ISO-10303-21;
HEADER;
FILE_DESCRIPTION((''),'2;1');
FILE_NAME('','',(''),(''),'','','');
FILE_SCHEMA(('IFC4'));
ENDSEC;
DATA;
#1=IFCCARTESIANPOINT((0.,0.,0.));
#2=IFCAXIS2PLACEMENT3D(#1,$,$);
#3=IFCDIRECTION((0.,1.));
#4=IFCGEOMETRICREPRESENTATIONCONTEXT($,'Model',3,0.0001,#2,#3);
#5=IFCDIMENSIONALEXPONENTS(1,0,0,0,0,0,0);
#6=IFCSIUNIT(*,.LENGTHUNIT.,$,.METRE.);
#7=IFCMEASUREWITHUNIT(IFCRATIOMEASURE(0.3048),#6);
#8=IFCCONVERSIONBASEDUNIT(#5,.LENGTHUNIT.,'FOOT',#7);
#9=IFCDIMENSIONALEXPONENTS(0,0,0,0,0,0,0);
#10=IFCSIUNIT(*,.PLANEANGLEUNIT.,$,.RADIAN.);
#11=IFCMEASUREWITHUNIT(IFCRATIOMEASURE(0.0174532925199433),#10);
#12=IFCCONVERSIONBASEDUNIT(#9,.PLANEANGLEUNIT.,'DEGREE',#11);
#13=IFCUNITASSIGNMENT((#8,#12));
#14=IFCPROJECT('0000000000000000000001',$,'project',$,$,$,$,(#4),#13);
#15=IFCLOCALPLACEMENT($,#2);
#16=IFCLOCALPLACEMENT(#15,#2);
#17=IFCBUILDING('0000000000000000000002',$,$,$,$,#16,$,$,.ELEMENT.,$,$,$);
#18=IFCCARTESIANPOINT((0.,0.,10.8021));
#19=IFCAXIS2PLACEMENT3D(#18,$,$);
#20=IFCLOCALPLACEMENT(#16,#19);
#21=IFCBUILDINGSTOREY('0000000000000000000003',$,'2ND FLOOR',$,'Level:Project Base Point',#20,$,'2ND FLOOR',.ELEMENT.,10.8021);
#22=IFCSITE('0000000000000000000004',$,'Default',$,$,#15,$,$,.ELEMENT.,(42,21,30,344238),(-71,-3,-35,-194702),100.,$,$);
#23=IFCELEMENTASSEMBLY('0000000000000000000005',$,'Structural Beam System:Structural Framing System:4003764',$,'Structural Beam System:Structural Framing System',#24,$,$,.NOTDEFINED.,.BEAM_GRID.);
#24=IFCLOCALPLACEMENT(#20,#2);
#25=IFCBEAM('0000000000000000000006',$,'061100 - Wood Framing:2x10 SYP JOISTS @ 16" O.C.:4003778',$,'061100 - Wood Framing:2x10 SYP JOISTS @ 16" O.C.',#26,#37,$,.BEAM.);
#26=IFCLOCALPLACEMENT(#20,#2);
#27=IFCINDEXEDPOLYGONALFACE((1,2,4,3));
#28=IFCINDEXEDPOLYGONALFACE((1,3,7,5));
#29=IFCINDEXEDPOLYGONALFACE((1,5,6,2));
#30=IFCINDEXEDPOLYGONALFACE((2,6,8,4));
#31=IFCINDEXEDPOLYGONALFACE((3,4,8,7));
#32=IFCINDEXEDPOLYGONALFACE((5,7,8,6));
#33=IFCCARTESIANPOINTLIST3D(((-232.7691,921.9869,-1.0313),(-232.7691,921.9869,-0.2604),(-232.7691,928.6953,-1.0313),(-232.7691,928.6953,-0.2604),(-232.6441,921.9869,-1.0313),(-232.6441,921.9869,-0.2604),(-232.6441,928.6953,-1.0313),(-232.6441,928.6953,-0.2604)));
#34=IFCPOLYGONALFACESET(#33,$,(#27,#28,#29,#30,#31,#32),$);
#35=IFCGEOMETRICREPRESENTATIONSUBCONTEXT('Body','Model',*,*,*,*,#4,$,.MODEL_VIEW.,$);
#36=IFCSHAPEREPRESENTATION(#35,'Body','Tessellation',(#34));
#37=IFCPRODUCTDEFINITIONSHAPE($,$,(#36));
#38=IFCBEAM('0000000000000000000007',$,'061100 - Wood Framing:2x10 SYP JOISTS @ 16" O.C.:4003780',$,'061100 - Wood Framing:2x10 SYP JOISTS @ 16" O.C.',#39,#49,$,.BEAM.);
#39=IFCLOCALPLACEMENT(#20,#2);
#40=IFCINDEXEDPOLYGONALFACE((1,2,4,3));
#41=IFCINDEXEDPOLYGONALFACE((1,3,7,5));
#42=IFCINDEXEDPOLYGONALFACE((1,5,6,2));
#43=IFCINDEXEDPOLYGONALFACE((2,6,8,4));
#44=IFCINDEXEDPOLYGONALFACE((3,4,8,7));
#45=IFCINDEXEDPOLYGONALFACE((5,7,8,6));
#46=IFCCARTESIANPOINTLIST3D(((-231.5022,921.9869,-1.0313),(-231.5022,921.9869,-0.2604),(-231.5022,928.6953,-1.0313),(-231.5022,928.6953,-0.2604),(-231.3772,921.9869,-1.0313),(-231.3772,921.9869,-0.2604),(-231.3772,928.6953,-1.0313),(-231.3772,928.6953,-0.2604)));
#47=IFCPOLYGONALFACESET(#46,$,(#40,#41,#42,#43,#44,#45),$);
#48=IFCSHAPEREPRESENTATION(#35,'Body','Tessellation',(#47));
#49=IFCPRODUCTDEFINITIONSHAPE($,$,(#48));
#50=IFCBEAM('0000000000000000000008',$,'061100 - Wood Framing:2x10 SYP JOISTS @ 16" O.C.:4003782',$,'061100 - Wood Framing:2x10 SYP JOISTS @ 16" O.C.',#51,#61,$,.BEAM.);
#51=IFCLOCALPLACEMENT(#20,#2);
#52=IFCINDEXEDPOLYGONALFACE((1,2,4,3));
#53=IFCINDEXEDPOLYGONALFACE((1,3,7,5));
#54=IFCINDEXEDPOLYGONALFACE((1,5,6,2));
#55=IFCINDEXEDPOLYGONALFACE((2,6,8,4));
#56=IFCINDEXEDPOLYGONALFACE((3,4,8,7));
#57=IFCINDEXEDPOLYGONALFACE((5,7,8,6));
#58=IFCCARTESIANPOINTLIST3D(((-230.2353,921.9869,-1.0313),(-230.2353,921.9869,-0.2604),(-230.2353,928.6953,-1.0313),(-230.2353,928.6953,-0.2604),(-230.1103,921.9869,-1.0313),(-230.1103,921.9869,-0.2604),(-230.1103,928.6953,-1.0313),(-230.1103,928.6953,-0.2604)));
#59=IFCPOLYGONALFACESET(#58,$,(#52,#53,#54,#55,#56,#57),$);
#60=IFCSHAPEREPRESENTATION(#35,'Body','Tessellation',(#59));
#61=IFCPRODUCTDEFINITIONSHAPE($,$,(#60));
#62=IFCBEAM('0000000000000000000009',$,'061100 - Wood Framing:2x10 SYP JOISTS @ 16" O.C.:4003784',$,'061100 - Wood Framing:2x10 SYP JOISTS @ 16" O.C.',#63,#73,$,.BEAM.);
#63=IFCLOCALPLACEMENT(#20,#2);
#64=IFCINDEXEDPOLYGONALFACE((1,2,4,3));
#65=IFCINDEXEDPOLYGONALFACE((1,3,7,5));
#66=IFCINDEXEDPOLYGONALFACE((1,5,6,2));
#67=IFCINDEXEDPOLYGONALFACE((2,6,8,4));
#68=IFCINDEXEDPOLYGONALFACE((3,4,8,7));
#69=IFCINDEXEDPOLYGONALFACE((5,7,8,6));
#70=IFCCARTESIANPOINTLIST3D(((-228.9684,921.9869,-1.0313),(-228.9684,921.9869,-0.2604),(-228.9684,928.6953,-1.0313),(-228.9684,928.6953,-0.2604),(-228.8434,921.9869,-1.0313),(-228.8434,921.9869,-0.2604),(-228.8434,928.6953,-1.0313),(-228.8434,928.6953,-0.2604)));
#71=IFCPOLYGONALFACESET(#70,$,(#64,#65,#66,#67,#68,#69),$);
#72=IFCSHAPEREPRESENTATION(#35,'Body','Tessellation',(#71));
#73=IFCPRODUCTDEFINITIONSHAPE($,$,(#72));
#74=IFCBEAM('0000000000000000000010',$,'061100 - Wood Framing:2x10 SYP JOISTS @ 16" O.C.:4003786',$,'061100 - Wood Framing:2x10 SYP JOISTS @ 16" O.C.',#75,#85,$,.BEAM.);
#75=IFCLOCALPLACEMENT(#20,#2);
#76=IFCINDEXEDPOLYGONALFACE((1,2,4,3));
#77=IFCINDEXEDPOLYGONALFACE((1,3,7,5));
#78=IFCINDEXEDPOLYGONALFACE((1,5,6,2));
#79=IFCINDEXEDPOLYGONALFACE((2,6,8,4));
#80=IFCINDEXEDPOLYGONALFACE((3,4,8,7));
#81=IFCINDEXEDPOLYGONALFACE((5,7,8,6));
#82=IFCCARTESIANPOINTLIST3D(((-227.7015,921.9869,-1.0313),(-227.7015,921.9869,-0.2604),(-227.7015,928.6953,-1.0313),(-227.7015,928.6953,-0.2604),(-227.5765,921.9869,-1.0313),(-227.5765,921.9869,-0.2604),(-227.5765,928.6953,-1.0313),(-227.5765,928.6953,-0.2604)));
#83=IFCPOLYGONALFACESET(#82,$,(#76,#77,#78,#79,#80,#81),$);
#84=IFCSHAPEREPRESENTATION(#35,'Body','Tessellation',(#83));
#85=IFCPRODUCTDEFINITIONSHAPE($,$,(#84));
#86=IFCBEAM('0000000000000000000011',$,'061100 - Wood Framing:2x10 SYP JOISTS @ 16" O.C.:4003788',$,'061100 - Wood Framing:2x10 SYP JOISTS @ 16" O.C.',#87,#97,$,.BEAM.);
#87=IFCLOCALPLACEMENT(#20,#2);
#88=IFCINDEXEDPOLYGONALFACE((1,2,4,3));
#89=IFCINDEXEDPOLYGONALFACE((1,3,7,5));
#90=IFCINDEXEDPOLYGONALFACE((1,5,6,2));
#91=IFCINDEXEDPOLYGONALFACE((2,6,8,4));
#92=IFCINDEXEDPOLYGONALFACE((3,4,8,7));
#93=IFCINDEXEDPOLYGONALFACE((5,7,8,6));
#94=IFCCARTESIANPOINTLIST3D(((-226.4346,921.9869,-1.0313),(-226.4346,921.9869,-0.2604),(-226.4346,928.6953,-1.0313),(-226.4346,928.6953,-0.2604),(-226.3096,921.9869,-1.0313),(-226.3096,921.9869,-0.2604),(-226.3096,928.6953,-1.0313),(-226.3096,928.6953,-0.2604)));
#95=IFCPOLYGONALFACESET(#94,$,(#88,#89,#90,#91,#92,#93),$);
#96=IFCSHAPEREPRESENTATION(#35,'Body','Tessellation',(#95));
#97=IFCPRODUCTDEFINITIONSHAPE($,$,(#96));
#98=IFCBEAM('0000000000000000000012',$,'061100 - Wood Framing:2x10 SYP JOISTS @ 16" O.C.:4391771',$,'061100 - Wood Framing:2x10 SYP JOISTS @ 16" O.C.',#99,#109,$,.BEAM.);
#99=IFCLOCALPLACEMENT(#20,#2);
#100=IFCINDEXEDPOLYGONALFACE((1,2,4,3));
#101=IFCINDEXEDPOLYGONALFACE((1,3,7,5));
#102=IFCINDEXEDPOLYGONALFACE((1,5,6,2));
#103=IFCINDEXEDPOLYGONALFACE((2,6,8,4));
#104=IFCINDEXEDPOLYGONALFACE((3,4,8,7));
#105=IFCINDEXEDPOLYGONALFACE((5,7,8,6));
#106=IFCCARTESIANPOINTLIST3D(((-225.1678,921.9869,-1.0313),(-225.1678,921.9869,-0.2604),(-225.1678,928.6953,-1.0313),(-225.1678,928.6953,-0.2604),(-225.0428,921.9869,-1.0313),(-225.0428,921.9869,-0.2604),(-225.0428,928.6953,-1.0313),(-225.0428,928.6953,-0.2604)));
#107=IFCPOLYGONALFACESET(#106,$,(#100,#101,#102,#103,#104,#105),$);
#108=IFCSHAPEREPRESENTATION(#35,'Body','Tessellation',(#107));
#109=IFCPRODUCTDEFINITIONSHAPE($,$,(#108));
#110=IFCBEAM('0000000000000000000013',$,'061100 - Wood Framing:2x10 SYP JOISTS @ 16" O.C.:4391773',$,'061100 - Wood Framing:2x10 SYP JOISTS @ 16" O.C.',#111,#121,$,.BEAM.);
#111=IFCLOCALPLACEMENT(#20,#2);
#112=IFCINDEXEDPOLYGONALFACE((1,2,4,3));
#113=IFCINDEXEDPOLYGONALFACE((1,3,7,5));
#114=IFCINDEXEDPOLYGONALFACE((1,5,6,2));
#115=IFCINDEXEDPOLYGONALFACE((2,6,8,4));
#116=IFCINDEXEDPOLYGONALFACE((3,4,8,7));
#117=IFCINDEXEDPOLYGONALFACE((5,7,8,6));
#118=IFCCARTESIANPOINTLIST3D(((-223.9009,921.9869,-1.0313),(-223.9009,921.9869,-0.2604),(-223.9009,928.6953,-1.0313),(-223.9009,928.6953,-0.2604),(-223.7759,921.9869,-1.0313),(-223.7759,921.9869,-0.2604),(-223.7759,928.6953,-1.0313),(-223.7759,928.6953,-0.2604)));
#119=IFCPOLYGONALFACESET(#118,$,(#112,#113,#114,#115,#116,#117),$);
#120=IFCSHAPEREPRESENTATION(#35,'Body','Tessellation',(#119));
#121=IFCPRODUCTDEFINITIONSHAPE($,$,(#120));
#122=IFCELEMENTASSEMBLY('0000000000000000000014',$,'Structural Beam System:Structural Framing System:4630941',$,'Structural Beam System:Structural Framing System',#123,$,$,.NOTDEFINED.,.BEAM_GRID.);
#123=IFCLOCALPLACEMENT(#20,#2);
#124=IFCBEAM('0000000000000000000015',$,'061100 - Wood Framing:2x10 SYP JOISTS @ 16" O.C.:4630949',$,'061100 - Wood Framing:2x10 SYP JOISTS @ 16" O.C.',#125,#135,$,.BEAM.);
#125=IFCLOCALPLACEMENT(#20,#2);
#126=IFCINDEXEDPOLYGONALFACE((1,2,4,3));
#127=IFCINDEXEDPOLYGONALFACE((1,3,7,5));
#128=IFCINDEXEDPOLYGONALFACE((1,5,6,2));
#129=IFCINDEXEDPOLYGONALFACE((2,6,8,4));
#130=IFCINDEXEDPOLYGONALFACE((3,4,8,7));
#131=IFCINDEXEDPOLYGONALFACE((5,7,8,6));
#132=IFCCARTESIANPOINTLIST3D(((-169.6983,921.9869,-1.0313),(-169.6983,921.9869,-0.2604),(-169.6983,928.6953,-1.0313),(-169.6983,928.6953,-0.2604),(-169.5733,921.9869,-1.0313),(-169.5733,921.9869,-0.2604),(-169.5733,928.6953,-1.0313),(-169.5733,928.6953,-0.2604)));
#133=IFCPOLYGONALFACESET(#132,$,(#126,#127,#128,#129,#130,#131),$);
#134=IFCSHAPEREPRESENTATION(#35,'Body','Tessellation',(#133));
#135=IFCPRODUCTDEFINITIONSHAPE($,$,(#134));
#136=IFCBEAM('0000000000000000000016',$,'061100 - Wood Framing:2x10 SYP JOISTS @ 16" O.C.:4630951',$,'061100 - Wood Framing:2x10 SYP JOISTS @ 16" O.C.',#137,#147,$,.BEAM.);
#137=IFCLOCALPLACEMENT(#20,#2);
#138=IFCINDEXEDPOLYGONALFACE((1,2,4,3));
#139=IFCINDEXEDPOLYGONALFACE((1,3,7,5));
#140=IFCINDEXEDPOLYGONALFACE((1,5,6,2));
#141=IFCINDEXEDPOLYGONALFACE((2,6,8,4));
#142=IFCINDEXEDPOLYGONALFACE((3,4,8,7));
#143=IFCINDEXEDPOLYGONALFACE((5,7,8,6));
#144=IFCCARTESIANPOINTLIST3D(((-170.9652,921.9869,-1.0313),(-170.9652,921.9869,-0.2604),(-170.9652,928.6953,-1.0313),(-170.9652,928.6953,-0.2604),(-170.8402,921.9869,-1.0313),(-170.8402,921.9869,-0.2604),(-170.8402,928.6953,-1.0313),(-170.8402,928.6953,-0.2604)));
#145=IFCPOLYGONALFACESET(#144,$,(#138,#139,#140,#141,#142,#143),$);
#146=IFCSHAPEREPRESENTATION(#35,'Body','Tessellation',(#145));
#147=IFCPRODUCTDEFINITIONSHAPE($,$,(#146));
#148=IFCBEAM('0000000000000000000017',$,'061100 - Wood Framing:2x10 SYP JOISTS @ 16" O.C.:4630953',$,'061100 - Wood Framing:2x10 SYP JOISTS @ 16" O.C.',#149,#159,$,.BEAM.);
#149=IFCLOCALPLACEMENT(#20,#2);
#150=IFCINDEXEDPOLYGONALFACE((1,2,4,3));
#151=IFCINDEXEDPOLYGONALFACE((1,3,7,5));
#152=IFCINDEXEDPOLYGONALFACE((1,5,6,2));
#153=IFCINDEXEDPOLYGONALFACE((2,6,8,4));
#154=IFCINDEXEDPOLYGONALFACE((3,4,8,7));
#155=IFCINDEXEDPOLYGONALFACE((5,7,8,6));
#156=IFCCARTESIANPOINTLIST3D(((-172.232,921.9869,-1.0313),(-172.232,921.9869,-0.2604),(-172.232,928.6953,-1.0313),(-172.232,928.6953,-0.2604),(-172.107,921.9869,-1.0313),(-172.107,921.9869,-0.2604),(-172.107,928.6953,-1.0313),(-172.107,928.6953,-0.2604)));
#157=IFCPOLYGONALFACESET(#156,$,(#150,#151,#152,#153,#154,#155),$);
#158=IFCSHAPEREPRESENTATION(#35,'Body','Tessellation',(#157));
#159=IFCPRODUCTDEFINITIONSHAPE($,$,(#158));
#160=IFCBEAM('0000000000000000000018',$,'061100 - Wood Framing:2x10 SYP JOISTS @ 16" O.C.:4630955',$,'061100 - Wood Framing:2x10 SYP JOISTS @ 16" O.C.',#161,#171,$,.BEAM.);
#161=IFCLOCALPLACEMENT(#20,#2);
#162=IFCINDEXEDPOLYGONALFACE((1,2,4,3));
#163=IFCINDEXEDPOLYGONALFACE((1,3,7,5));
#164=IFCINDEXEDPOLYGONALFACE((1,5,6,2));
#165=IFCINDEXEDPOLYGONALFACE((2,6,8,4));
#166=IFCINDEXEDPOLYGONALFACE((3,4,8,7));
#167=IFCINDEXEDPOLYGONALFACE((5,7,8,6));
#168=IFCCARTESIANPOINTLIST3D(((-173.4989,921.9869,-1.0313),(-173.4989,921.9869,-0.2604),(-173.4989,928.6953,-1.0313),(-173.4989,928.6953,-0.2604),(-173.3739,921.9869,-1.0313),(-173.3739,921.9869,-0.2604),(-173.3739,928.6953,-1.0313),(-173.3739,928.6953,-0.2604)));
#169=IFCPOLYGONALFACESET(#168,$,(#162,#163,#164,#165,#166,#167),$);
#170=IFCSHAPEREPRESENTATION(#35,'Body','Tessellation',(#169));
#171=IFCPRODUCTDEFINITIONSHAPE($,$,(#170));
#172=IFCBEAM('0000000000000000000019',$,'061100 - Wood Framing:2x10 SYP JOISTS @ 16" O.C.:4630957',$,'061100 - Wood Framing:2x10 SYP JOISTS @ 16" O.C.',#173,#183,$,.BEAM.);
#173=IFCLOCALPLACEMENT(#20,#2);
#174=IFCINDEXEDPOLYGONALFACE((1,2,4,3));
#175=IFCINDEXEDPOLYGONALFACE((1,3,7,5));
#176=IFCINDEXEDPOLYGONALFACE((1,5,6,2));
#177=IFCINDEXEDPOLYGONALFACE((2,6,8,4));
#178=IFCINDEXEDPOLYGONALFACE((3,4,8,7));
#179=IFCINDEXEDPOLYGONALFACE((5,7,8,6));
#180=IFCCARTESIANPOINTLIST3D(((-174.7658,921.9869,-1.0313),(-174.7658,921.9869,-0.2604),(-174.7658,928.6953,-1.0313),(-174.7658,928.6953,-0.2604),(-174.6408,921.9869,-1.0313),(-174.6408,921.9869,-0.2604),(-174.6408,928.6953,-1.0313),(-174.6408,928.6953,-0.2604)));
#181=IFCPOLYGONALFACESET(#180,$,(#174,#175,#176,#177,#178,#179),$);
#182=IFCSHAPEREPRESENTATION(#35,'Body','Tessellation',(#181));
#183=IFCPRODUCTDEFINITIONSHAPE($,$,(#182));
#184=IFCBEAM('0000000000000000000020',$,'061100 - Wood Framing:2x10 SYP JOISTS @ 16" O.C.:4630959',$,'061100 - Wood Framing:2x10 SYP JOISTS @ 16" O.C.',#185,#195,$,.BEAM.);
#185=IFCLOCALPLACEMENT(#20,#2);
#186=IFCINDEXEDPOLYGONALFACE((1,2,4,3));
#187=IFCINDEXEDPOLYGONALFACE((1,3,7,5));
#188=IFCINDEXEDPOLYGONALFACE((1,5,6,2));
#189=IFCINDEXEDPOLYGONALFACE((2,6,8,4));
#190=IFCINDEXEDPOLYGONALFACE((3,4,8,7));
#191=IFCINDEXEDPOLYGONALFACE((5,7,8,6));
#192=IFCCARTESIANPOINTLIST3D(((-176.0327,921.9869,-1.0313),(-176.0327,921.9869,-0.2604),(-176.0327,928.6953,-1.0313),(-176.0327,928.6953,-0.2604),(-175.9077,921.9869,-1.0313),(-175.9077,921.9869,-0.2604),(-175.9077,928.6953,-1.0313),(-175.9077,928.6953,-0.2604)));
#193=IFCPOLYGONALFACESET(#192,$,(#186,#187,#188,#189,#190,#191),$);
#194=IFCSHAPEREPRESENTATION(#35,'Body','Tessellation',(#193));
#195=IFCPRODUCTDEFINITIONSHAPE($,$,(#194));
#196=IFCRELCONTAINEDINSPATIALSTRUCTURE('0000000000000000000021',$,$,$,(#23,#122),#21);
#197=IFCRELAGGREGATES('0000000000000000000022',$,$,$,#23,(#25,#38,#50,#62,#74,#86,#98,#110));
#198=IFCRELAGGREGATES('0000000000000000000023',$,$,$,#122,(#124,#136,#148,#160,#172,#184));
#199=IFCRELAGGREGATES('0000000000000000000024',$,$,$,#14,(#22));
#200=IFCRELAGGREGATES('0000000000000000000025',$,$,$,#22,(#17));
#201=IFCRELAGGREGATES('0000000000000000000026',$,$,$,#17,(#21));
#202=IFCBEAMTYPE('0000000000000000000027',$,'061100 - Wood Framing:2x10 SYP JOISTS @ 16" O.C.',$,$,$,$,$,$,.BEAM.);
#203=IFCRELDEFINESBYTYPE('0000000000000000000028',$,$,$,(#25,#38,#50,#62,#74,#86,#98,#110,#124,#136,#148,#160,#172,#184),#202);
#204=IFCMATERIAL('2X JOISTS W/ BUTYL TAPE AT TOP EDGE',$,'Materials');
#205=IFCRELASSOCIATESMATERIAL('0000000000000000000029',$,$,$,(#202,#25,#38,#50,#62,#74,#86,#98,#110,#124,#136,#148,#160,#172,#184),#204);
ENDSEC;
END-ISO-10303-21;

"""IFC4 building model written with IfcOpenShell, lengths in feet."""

from ifc_helpers import new_model, entity, si_unit, converted_unit, direction, frame, frame_2d, origin, place, context, subcontext, project, spatial, rectangle, extrude, source, transform, mapped, material, material_profile, profile_set, profile_usage, type_object, type_shapes, element, aggregate, save


model = new_model("IFC4")

# Units and contexts
model_context = context("Model", 3, precision=0.0001, world=origin(), true_north=direction((0.0, 1.0)))
body_context = subcontext(model_context, "Body", "Model", "MODEL_VIEW")
ifc_project = project(units=[converted_unit("LENGTHUNIT", "FOOT", entity("IfcRatioMeasure", 0.3048), si_unit("LENGTHUNIT", "METRE"), dimensions=[1, 0, 0, 0, 0, 0, 0]), converted_unit("PLANEANGLEUNIT", "DEGREE", entity("IfcRatioMeasure", 0.0174532925199433), si_unit("PLANEANGLEUNIT", "RADIAN"), dimensions=[0, 0, 0, 0, 0, 0, 0])], contexts=[model_context])

# Site, building, storey
site_placement = place(None, origin())
site = spatial("IfcSite", under=ifc_project, at=site_placement, Name="Default", CompositionType="ELEMENT", RefLatitude=(42, 21, 30, 344238), RefLongitude=(-71, -3, -35, -194702), RefElevation=100.0)
building_placement = place(site_placement, origin())
building = spatial("IfcBuilding", under=site, at=building_placement, CompositionType="ELEMENT")
storey_placement = place(building_placement, frame((0.0, 0.0, 10.8021)))
storey = spatial("IfcBuildingStorey", under=building, at=storey_placement, Name="2ND FLOOR", ObjectType="Level:Project Base Point", LongName="2ND FLOOR", CompositionType="ELEMENT", Elevation=10.8021)

# Element assemblies, beams
assembly_1_placement = place(storey_placement, origin())
assembly_1 = element("IfcElementAssembly", 1, at=assembly_1_placement, inside=storey, Name="Structural Beam System:Structural Framing System:4003764", ObjectType="Structural Beam System:Structural Framing System", AssemblyPlace="NOTDEFINED", PredefinedType="BEAM_GRID")
ifc_material_1 = material(Name="2X JOISTS W/ BUTYL TAPE AT TOP EDGE", Category="Materials")
ifc_material_profile_1 = material_profile(ifc_material_1, rectangle(XDim=0.7708, YDim=0.125, at=frame_2d((0.0, 0.0), x_axis=(1.0, 0.0))), Name="2x10 SYP JOISTS @ 16\" O.C.")
ifc_profile_set_1 = profile_set([ifc_material_profile_1], Name="2x10 SYP JOISTS @ 16\" O.C.")
ifc_profile_usage_1 = profile_usage(ifc_profile_set_1, cardinal=8)
beam_type_1 = type_object("IfcBeamType", Name="061100 - Wood Framing:2x10 SYP JOISTS @ 16\" O.C.", PredefinedType="BEAM", material=ifc_profile_set_1)
shared_shape_1 = source(origin(), body_context, "Body", "SweptSolid", [
    extrude(rectangle(XDim=0.7708, YDim=0.125, at=frame_2d((0.0, 0.0), x_axis=(1.0, 0.0))), frame((-3.3542, 0.0, 0.0), z_axis=(1.0, 0.0, 0.0), x_axis=(0.0, 0.0, -1.0)), (0.0, 0.0, 1.0), 6.7083),
])
type_shapes(beam_type_1, [shared_shape_1])
beam_1_placement = place(assembly_1_placement, frame((-232.7066, 925.3411, -0.6458), z_axis=(0.0, 0.0, 1.0), x_axis=(0.0, 1.0, 0.0)))
beam_1 = element("IfcBeam", 2, at=beam_1_placement, type_object=beam_type_1, material=ifc_profile_usage_1, Name="061100 - Wood Framing:2x10 SYP JOISTS @ 16\" O.C.:4003778", ObjectType="061100 - Wood Framing:2x10 SYP JOISTS @ 16\" O.C.", PredefinedType="BEAM", context=body_context, shape_type="MappedRepresentation", body=[
    mapped(shared_shape_1, transform((0.0, 0.0, 0.0), scale=1.0)),
])
ifc_profile_usage_2 = profile_usage(ifc_profile_set_1, cardinal=8)
beam_2_placement = place(assembly_1_placement, frame((-231.4397, 925.3411, -0.6458), z_axis=(0.0, 0.0, 1.0), x_axis=(0.0, 1.0, 0.0)))
beam_2 = element("IfcBeam", 3, at=beam_2_placement, type_object=beam_type_1, material=ifc_profile_usage_2, Name="061100 - Wood Framing:2x10 SYP JOISTS @ 16\" O.C.:4003780", ObjectType="061100 - Wood Framing:2x10 SYP JOISTS @ 16\" O.C.", PredefinedType="BEAM", context=body_context, shape_type="MappedRepresentation", body=[
    mapped(shared_shape_1, transform((0.0, 0.0, 0.0), scale=1.0)),
])
ifc_profile_usage_3 = profile_usage(ifc_profile_set_1, cardinal=8)
beam_3_placement = place(assembly_1_placement, frame((-230.1728, 925.3411, -0.6458), z_axis=(0.0, 0.0, 1.0), x_axis=(0.0, 1.0, 0.0)))
beam_3 = element("IfcBeam", 4, at=beam_3_placement, type_object=beam_type_1, material=ifc_profile_usage_3, Name="061100 - Wood Framing:2x10 SYP JOISTS @ 16\" O.C.:4003782", ObjectType="061100 - Wood Framing:2x10 SYP JOISTS @ 16\" O.C.", PredefinedType="BEAM", context=body_context, shape_type="MappedRepresentation", body=[
    mapped(shared_shape_1, transform((0.0, 0.0, 0.0), scale=1.0)),
])
ifc_profile_usage_4 = profile_usage(ifc_profile_set_1, cardinal=8)
beam_4_placement = place(assembly_1_placement, frame((-228.9059, 925.3411, -0.6458), z_axis=(0.0, 0.0, 1.0), x_axis=(0.0, 1.0, 0.0)))
beam_4 = element("IfcBeam", 5, at=beam_4_placement, type_object=beam_type_1, material=ifc_profile_usage_4, Name="061100 - Wood Framing:2x10 SYP JOISTS @ 16\" O.C.:4003784", ObjectType="061100 - Wood Framing:2x10 SYP JOISTS @ 16\" O.C.", PredefinedType="BEAM", context=body_context, shape_type="MappedRepresentation", body=[
    mapped(shared_shape_1, transform((0.0, 0.0, 0.0), scale=1.0)),
])
ifc_profile_usage_5 = profile_usage(ifc_profile_set_1, cardinal=8)
beam_5_placement = place(assembly_1_placement, frame((-227.639, 925.3411, -0.6458), z_axis=(0.0, 0.0, 1.0), x_axis=(0.0, 1.0, 0.0)))
beam_5 = element("IfcBeam", 6, at=beam_5_placement, type_object=beam_type_1, material=ifc_profile_usage_5, Name="061100 - Wood Framing:2x10 SYP JOISTS @ 16\" O.C.:4003786", ObjectType="061100 - Wood Framing:2x10 SYP JOISTS @ 16\" O.C.", PredefinedType="BEAM", context=body_context, shape_type="MappedRepresentation", body=[
    mapped(shared_shape_1, transform((0.0, 0.0, 0.0), scale=1.0)),
])
ifc_profile_usage_6 = profile_usage(ifc_profile_set_1, cardinal=8)
beam_6_placement = place(assembly_1_placement, frame((-226.3721, 925.3411, -0.6458), z_axis=(0.0, 0.0, 1.0), x_axis=(0.0, 1.0, 0.0)))
beam_6 = element("IfcBeam", 7, at=beam_6_placement, type_object=beam_type_1, material=ifc_profile_usage_6, Name="061100 - Wood Framing:2x10 SYP JOISTS @ 16\" O.C.:4003788", ObjectType="061100 - Wood Framing:2x10 SYP JOISTS @ 16\" O.C.", PredefinedType="BEAM", context=body_context, shape_type="MappedRepresentation", body=[
    mapped(shared_shape_1, transform((0.0, 0.0, 0.0), scale=1.0)),
])
ifc_profile_usage_7 = profile_usage(ifc_profile_set_1, cardinal=8)
beam_7_placement = place(assembly_1_placement, frame((-225.1053, 925.3411, -0.6458), z_axis=(0.0, 0.0, 1.0), x_axis=(0.0, 1.0, 0.0)))
beam_7 = element("IfcBeam", 8, at=beam_7_placement, type_object=beam_type_1, material=ifc_profile_usage_7, Name="061100 - Wood Framing:2x10 SYP JOISTS @ 16\" O.C.:4391771", ObjectType="061100 - Wood Framing:2x10 SYP JOISTS @ 16\" O.C.", PredefinedType="BEAM", context=body_context, shape_type="MappedRepresentation", body=[
    mapped(shared_shape_1, transform((0.0, 0.0, 0.0), scale=1.0)),
])
ifc_profile_usage_8 = profile_usage(ifc_profile_set_1, cardinal=8)
beam_8_placement = place(assembly_1_placement, frame((-223.8384, 925.3411, -0.6458), z_axis=(0.0, 0.0, 1.0), x_axis=(0.0, 1.0, 0.0)))
beam_8 = element("IfcBeam", 9, at=beam_8_placement, type_object=beam_type_1, material=ifc_profile_usage_8, Name="061100 - Wood Framing:2x10 SYP JOISTS @ 16\" O.C.:4391773", ObjectType="061100 - Wood Framing:2x10 SYP JOISTS @ 16\" O.C.", PredefinedType="BEAM", context=body_context, shape_type="MappedRepresentation", body=[
    mapped(shared_shape_1, transform((0.0, 0.0, 0.0), scale=1.0)),
])
aggregate(assembly_1, [beam_1, beam_2, beam_3, beam_4, beam_5, beam_6, beam_7, beam_8])
assembly_2_placement = place(storey_placement, origin())
assembly_2 = element("IfcElementAssembly", 10, at=assembly_2_placement, inside=storey, Name="Structural Beam System:Structural Framing System:4630941", ObjectType="Structural Beam System:Structural Framing System", AssemblyPlace="NOTDEFINED", PredefinedType="BEAM_GRID")
ifc_profile_usage_9 = profile_usage(ifc_profile_set_1, cardinal=8)
beam_9_placement = place(assembly_2_placement, frame((-169.6358, 925.3411, -0.6458), z_axis=(0.0, 0.0, 1.0), x_axis=(0.0, 1.0, 0.0)))
beam_9 = element("IfcBeam", 11, at=beam_9_placement, type_object=beam_type_1, material=ifc_profile_usage_9, Name="061100 - Wood Framing:2x10 SYP JOISTS @ 16\" O.C.:4630949", ObjectType="061100 - Wood Framing:2x10 SYP JOISTS @ 16\" O.C.", PredefinedType="BEAM", context=body_context, shape_type="MappedRepresentation", body=[
    mapped(shared_shape_1, transform((0.0, 0.0, 0.0), scale=1.0)),
])
ifc_profile_usage_10 = profile_usage(ifc_profile_set_1, cardinal=8)
beam_10_placement = place(assembly_2_placement, frame((-170.9027, 925.3411, -0.6458), z_axis=(0.0, 0.0, 1.0), x_axis=(0.0, 1.0, 0.0)))
beam_10 = element("IfcBeam", 12, at=beam_10_placement, type_object=beam_type_1, material=ifc_profile_usage_10, Name="061100 - Wood Framing:2x10 SYP JOISTS @ 16\" O.C.:4630951", ObjectType="061100 - Wood Framing:2x10 SYP JOISTS @ 16\" O.C.", PredefinedType="BEAM", context=body_context, shape_type="MappedRepresentation", body=[
    mapped(shared_shape_1, transform((0.0, 0.0, 0.0), scale=1.0)),
])
ifc_profile_usage_11 = profile_usage(ifc_profile_set_1, cardinal=8)
beam_11_placement = place(assembly_2_placement, frame((-172.1695, 925.3411, -0.6458), z_axis=(0.0, 0.0, 1.0), x_axis=(0.0, 1.0, 0.0)))
beam_11 = element("IfcBeam", 13, at=beam_11_placement, type_object=beam_type_1, material=ifc_profile_usage_11, Name="061100 - Wood Framing:2x10 SYP JOISTS @ 16\" O.C.:4630953", ObjectType="061100 - Wood Framing:2x10 SYP JOISTS @ 16\" O.C.", PredefinedType="BEAM", context=body_context, shape_type="MappedRepresentation", body=[
    mapped(shared_shape_1, transform((0.0, 0.0, 0.0), scale=1.0)),
])
ifc_profile_usage_12 = profile_usage(ifc_profile_set_1, cardinal=8)
beam_12_placement = place(assembly_2_placement, frame((-173.4364, 925.3411, -0.6458), z_axis=(0.0, 0.0, 1.0), x_axis=(0.0, 1.0, 0.0)))
beam_12 = element("IfcBeam", 14, at=beam_12_placement, type_object=beam_type_1, material=ifc_profile_usage_12, Name="061100 - Wood Framing:2x10 SYP JOISTS @ 16\" O.C.:4630955", ObjectType="061100 - Wood Framing:2x10 SYP JOISTS @ 16\" O.C.", PredefinedType="BEAM", context=body_context, shape_type="MappedRepresentation", body=[
    mapped(shared_shape_1, transform((0.0, 0.0, 0.0), scale=1.0)),
])
ifc_profile_usage_13 = profile_usage(ifc_profile_set_1, cardinal=8)
beam_13_placement = place(assembly_2_placement, frame((-174.7033, 925.3411, -0.6458), z_axis=(0.0, 0.0, 1.0), x_axis=(0.0, 1.0, 0.0)))
beam_13 = element("IfcBeam", 15, at=beam_13_placement, type_object=beam_type_1, material=ifc_profile_usage_13, Name="061100 - Wood Framing:2x10 SYP JOISTS @ 16\" O.C.:4630957", ObjectType="061100 - Wood Framing:2x10 SYP JOISTS @ 16\" O.C.", PredefinedType="BEAM", context=body_context, shape_type="MappedRepresentation", body=[
    mapped(shared_shape_1, transform((0.0, 0.0, 0.0), scale=1.0)),
])
ifc_profile_usage_14 = profile_usage(ifc_profile_set_1, cardinal=8)
beam_14_placement = place(assembly_2_placement, frame((-175.9702, 925.3411, -0.6458), z_axis=(0.0, 0.0, 1.0), x_axis=(0.0, 1.0, 0.0)))
beam_14 = element("IfcBeam", 16, at=beam_14_placement, type_object=beam_type_1, material=ifc_profile_usage_14, Name="061100 - Wood Framing:2x10 SYP JOISTS @ 16\" O.C.:4630959", ObjectType="061100 - Wood Framing:2x10 SYP JOISTS @ 16\" O.C.", PredefinedType="BEAM", context=body_context, shape_type="MappedRepresentation", body=[
    mapped(shared_shape_1, transform((0.0, 0.0, 0.0), scale=1.0)),
])
aggregate(assembly_2, [beam_9, beam_10, beam_11, beam_12, beam_13, beam_14])

save(model, "model.ifc")
